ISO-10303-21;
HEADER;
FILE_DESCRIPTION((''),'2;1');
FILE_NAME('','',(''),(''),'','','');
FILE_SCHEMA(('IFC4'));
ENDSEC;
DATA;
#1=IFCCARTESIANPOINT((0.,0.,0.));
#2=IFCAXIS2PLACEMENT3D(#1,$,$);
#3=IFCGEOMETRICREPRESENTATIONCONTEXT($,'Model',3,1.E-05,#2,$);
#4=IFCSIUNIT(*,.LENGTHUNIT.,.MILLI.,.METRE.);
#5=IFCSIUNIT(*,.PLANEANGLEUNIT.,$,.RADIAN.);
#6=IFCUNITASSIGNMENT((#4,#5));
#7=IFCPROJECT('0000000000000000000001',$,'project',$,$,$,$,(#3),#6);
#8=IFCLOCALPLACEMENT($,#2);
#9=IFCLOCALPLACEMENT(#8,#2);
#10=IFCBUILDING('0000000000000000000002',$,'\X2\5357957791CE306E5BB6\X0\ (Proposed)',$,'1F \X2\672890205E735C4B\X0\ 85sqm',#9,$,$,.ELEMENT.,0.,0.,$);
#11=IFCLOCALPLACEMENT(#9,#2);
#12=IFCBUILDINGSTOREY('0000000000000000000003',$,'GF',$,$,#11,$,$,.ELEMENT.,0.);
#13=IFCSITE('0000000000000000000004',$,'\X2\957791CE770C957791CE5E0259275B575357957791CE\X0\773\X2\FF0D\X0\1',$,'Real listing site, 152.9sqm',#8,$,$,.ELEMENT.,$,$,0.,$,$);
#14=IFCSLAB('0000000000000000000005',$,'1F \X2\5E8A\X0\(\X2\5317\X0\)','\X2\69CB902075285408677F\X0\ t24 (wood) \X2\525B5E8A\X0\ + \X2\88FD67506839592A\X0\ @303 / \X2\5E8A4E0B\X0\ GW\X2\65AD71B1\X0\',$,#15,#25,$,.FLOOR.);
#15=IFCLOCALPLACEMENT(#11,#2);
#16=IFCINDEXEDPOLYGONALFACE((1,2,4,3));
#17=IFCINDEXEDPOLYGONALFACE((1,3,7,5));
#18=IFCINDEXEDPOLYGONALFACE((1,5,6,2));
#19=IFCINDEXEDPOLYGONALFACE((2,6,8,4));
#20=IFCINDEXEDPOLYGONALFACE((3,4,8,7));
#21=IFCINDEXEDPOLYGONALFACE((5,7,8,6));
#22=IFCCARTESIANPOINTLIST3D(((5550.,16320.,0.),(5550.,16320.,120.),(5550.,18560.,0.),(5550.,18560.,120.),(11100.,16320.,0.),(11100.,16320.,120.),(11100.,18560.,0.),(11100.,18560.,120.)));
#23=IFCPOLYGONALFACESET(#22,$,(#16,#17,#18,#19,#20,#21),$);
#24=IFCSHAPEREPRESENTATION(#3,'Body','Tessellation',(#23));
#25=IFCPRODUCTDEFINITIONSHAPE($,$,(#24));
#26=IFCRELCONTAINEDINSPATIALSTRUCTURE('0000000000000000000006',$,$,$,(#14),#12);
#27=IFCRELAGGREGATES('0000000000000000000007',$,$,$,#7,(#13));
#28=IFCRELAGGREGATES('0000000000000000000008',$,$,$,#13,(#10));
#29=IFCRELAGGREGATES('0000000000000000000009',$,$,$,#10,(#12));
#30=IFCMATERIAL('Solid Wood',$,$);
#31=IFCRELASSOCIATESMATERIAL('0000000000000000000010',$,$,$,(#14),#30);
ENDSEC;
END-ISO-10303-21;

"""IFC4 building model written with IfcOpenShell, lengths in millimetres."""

from ifc_helpers import new_model, si_unit, frame, frame_2d, origin, place, context, project, spatial, rectangle, extrude, material, element, save


model = new_model("IFC4")

# Units and contexts
model_context = context("Model", 3, precision=1e-05, world=origin())
ifc_project = project(units=[si_unit("LENGTHUNIT", "METRE", prefix="MILLI"), si_unit("PLANEANGLEUNIT", "RADIAN")], contexts=[model_context])

# Site, building, storey
site_placement = place(None, origin())
site = spatial("IfcSite", under=ifc_project, at=site_placement, Name="長野県長野市大字南長野773－1", ObjectType="Real listing site, 152.9sqm", CompositionType="ELEMENT", RefElevation=0.0)
building_placement = place(site_placement, origin())
building = spatial("IfcBuilding", under=site, at=building_placement, Name="南長野の家 (Proposed)", ObjectType="1F 木造平屋 85sqm", CompositionType="ELEMENT", ElevationOfRefHeight=0.0, ElevationOfTerrain=0.0)
storey_placement = place(building_placement, origin())
storey = spatial("IfcBuildingStorey", under=building, at=storey_placement, Name="GF", CompositionType="ELEMENT", Elevation=0.0)

# Slab
ifc_material_1 = material(Name="Solid Wood")
slab_1_placement = place(storey_placement, frame((2775.0, 8160.0, 0.0)))
element("IfcSlab", 1, at=slab_1_placement, inside=storey, material=ifc_material_1, Name="1F 床(北)", Description="構造用合板 t24 (wood) 剛床 + 製材根太 @303 / 床下 GW断熱", PredefinedType="FLOOR", context=model_context, shape_type="SweptSolid", body=[
    extrude(rectangle(XDim=5550.0, YDim=2240.0, at=frame_2d((2775.0, 1120.0))), frame((2775.0, 8160.0, 0.0)), (0.0, 0.0, 1.0), 120.0),
])

save(model, "model.ifc")
